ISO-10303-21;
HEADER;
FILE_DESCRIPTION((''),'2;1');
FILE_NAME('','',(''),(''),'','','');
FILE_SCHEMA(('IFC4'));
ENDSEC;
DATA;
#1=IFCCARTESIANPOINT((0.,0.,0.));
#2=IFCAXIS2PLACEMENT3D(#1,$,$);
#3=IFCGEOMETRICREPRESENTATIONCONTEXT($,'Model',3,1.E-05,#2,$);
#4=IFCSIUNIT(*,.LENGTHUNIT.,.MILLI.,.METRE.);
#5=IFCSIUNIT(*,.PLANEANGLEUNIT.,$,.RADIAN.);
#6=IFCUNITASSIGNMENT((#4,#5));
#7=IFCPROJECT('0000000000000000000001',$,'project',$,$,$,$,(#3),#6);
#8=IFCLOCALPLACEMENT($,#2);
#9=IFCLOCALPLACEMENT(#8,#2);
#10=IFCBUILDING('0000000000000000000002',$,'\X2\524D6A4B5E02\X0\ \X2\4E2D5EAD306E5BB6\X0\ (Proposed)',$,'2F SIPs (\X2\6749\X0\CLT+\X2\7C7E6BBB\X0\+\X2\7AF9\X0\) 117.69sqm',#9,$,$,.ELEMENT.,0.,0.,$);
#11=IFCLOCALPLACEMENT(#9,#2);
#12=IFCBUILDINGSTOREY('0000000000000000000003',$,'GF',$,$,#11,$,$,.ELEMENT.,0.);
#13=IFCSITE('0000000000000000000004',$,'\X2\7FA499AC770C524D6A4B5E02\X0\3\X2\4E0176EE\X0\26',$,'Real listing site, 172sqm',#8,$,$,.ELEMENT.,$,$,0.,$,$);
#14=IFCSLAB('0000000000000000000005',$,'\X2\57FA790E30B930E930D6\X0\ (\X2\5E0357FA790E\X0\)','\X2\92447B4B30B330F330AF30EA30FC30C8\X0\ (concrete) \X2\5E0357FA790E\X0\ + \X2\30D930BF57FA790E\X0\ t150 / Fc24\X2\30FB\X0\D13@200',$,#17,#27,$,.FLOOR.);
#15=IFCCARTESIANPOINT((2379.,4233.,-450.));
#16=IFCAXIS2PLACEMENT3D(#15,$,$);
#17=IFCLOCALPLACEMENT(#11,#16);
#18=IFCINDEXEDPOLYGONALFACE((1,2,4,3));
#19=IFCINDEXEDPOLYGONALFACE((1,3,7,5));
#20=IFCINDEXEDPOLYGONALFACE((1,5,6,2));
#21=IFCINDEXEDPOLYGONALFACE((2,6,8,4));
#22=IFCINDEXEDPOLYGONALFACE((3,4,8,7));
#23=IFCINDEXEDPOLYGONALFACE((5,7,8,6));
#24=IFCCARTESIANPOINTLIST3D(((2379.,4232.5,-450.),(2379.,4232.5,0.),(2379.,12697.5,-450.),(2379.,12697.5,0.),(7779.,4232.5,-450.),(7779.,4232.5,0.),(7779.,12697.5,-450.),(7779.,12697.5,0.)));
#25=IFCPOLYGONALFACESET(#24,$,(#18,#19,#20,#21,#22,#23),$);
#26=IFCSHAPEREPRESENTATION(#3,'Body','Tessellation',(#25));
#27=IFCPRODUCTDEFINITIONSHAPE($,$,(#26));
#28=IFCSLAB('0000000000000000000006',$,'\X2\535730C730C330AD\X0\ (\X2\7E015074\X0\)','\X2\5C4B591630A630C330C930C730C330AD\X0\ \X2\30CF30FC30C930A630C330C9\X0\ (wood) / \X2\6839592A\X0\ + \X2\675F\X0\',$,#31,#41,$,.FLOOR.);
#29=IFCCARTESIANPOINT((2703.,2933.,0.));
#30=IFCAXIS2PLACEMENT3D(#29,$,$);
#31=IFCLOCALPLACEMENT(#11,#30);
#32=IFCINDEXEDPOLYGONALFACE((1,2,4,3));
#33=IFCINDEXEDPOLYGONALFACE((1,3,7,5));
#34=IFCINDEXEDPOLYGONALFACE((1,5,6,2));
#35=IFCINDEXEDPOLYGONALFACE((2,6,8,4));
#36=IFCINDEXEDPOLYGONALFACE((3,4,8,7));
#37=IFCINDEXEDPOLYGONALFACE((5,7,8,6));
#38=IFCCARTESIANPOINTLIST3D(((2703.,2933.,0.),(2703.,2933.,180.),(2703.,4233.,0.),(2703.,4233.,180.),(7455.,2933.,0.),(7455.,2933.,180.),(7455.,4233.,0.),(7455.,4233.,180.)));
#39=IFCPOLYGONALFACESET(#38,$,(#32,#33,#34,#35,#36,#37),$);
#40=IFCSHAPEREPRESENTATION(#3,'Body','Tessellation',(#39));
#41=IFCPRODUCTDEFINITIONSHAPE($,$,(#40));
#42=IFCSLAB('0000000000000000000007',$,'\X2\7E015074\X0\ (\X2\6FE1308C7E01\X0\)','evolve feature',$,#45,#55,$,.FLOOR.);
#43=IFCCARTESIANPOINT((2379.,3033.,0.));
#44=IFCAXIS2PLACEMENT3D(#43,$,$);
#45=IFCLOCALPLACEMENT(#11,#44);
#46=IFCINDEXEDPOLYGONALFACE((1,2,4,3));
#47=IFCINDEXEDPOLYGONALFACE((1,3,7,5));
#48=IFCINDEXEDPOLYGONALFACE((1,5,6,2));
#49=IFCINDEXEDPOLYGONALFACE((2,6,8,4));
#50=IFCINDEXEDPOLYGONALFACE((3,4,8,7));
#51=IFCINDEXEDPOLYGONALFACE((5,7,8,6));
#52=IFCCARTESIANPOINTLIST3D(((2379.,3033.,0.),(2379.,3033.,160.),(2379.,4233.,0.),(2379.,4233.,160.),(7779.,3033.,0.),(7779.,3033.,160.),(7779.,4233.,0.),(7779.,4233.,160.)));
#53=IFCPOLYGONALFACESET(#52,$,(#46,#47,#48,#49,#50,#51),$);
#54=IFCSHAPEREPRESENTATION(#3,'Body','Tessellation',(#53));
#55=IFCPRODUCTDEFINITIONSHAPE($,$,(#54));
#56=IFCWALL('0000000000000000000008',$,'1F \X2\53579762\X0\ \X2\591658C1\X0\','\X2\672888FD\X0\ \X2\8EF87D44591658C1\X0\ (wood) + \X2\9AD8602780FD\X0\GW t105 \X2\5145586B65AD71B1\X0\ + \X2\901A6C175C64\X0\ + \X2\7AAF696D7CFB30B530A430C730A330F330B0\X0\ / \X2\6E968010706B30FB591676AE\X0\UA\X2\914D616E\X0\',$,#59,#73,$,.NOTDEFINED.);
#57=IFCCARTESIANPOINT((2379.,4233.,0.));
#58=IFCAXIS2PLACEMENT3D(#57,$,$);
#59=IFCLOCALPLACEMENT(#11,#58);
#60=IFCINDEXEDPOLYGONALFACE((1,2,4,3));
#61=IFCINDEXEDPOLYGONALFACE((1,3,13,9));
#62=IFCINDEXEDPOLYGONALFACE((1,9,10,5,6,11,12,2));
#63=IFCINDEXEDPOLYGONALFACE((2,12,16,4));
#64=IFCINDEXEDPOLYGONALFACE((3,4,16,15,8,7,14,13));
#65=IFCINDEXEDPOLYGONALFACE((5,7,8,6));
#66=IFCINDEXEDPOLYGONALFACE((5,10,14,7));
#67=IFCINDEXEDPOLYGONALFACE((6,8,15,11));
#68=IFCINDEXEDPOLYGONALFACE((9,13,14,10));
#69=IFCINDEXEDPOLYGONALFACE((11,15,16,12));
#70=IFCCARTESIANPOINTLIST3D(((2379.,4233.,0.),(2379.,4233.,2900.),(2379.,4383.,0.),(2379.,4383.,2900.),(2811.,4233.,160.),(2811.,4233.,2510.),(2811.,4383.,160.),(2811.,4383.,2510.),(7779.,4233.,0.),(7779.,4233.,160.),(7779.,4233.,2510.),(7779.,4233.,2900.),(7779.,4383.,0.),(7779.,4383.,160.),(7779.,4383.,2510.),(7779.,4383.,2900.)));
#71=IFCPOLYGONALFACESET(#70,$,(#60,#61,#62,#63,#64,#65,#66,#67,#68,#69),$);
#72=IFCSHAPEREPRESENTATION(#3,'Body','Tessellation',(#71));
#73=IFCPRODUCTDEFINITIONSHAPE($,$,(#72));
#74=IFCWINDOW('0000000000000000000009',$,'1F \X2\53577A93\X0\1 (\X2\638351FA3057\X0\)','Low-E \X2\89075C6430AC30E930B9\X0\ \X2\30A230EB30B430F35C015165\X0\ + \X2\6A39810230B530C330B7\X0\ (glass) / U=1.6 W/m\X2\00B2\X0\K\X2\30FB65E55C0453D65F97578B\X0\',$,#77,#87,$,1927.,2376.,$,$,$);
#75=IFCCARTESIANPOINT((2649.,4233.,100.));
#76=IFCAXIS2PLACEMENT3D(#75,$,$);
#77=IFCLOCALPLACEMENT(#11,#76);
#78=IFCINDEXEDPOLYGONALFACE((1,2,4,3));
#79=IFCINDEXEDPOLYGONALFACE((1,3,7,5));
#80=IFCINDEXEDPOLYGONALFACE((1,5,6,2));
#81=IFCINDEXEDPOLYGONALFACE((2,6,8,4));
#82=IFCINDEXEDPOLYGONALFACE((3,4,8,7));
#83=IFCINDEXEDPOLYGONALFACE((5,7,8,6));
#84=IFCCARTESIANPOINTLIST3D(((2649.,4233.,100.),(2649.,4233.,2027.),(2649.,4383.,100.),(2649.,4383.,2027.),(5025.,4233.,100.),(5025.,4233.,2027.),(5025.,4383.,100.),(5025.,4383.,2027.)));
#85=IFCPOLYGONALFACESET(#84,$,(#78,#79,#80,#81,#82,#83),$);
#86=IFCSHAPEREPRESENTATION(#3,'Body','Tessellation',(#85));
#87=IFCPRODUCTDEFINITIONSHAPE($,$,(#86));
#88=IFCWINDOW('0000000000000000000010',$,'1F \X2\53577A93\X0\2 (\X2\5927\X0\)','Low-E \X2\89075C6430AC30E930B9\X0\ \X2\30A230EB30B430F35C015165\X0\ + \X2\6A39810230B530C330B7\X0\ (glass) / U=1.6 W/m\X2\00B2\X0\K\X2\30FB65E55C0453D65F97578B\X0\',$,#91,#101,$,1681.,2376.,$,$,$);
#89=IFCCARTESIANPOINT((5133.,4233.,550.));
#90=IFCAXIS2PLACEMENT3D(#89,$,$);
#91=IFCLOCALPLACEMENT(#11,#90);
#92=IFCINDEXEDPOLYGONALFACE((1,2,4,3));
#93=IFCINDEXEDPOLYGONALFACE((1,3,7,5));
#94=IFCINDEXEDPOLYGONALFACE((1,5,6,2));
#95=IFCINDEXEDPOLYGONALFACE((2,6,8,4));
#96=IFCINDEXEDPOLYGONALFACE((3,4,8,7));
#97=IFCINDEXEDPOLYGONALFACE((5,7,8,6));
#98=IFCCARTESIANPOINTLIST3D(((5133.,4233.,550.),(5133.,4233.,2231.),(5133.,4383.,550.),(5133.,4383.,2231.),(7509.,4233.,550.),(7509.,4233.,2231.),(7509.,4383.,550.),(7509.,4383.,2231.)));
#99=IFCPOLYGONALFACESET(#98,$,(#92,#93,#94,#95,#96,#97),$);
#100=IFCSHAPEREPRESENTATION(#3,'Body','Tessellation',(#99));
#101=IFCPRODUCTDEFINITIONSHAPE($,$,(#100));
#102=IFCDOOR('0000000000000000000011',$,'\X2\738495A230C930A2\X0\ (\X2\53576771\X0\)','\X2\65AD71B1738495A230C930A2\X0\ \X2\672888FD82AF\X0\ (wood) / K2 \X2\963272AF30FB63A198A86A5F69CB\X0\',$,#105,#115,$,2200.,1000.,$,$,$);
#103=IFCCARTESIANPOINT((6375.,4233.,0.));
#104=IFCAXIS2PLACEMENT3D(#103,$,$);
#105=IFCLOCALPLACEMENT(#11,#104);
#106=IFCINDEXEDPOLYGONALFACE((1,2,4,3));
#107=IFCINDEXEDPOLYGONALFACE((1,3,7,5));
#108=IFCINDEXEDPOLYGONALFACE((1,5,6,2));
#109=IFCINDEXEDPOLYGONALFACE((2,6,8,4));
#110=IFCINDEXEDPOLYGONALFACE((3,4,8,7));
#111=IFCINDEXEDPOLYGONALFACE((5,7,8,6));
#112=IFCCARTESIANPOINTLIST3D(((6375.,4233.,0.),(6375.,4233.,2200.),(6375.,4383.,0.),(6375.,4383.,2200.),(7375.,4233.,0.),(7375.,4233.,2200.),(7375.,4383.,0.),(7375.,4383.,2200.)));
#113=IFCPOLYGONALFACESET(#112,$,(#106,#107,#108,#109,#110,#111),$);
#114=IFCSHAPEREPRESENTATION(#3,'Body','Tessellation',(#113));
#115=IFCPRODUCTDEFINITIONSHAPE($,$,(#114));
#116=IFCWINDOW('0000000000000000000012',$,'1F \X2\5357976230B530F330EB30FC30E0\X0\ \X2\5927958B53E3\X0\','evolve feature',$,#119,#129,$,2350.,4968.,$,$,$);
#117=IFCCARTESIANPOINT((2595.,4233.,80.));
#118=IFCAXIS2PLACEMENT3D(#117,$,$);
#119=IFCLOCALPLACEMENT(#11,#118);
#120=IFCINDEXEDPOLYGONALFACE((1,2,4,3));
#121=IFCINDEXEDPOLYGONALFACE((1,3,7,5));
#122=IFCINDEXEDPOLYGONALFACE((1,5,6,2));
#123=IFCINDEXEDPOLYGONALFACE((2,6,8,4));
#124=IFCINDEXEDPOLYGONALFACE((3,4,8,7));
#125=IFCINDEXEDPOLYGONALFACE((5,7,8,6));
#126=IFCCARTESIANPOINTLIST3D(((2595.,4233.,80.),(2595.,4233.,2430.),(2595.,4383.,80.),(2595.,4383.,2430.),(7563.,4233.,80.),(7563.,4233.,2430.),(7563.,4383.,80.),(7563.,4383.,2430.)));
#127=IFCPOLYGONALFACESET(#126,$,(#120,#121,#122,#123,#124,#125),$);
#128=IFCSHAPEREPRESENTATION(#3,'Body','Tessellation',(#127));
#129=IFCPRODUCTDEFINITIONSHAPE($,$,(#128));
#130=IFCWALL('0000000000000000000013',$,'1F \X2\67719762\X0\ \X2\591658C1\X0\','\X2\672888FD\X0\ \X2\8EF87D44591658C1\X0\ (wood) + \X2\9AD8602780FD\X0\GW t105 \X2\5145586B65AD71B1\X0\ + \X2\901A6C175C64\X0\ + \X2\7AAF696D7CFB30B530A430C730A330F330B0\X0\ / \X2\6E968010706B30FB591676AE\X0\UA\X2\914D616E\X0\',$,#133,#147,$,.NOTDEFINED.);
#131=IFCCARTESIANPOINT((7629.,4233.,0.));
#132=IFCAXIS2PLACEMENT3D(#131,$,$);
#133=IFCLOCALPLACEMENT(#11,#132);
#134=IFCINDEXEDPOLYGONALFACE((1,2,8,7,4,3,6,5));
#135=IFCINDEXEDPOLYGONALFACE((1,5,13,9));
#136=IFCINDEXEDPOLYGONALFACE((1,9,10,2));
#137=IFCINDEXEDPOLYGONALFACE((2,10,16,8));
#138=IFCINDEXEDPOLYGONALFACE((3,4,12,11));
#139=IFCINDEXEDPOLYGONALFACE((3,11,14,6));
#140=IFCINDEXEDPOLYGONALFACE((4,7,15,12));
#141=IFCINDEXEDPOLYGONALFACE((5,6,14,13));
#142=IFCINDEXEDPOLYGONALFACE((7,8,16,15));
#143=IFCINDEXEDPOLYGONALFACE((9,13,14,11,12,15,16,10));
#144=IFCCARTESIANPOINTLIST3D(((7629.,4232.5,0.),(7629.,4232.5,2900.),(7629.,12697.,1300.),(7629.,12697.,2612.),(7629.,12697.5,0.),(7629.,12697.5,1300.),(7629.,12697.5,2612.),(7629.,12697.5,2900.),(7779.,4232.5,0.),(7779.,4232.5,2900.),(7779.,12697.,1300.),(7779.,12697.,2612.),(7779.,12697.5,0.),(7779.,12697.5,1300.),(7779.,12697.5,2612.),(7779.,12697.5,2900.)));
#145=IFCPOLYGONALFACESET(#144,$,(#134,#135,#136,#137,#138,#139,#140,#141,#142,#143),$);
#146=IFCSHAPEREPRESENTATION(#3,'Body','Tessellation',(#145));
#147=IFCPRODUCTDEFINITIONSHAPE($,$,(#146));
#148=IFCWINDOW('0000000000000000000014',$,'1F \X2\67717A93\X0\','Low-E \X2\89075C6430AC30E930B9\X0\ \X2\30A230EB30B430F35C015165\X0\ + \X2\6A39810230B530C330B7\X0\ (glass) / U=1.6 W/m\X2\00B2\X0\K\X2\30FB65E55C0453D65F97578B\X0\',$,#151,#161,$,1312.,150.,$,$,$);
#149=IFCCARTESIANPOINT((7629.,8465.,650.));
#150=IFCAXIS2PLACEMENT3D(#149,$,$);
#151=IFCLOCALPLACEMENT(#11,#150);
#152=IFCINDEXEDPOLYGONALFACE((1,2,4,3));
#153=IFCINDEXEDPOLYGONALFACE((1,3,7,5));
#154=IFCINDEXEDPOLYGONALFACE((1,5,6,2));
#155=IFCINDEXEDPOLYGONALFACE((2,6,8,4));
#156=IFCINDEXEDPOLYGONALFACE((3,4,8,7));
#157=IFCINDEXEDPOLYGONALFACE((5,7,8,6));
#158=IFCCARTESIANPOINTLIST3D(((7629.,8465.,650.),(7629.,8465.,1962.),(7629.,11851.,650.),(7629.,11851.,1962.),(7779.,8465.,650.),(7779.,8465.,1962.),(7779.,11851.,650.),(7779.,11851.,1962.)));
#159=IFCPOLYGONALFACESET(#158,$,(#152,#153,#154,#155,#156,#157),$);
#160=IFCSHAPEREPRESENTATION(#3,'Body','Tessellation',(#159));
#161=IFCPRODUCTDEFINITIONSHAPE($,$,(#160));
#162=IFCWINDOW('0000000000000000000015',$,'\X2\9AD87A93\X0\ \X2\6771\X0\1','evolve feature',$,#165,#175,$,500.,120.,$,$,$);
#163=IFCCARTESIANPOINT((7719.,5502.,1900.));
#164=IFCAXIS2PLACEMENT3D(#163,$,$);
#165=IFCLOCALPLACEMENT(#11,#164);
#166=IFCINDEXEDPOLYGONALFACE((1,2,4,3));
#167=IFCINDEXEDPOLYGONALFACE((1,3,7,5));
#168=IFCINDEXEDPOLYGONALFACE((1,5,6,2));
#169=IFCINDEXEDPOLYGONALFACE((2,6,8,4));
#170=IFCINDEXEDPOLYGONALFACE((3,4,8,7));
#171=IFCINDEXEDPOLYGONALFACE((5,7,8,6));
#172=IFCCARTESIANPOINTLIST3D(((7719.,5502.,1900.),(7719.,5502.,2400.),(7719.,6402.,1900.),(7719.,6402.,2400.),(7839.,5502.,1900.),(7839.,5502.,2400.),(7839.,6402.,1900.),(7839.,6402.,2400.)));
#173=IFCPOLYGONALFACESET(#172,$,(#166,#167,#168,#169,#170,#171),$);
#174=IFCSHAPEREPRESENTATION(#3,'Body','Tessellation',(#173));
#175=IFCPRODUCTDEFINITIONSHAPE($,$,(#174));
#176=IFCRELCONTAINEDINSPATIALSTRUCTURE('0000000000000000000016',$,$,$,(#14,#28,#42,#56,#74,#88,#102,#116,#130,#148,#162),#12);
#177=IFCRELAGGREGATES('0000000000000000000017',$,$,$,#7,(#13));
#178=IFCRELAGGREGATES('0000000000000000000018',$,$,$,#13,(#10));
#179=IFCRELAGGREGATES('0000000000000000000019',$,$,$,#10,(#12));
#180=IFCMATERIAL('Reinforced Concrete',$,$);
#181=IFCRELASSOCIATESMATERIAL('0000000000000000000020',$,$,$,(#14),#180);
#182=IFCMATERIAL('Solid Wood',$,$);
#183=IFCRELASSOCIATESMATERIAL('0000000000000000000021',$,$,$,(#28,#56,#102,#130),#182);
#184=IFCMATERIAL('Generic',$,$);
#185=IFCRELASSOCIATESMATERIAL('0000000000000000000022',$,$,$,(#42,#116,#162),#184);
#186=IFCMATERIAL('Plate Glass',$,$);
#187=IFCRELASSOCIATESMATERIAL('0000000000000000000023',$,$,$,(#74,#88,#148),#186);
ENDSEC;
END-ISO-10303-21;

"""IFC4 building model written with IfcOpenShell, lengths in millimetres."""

from ifc_helpers import new_model, si_unit, frame, frame_2d, origin, place, context, project, spatial, rectangle, extrude, material, element, fill, save


model = new_model("IFC4")

# Units and contexts
model_context = context("Model", 3, precision=1e-05, world=origin())
ifc_project = project(units=[si_unit("LENGTHUNIT", "METRE", prefix="MILLI"), si_unit("PLANEANGLEUNIT", "RADIAN")], contexts=[model_context])

# Site, building, storey
site_placement = place(None, origin())
site = spatial("IfcSite", under=ifc_project, at=site_placement, Name="群馬県前橋市3丁目26", ObjectType="Real listing site, 172sqm", CompositionType="ELEMENT", RefElevation=0.0)
building_placement = place(site_placement, origin())
building = spatial("IfcBuilding", under=site, at=building_placement, Name="前橋市 中庭の家 (Proposed)", ObjectType="2F SIPs (杉CLT+籾殻+竹) 117.69sqm", CompositionType="ELEMENT", ElevationOfRefHeight=0.0, ElevationOfTerrain=0.0)
storey_placement = place(building_placement, origin())
storey = spatial("IfcBuildingStorey", under=building, at=storey_placement, Name="GF", CompositionType="ELEMENT", Elevation=0.0)

# Slabs
ifc_material_1 = material(Name="Reinforced Concrete")
slab_1_placement = place(storey_placement, frame((2379.0, 4233.0, -450.0)))
element("IfcSlab", 1, at=slab_1_placement, inside=storey, material=ifc_material_1, Name="基礎スラブ (布基礎)", Description="鉄筋コンクリート (concrete) 布基礎 + ベタ基礎 t150 / Fc24・D13@200", PredefinedType="FLOOR", context=model_context, shape_type="SweptSolid", body=[
    extrude(rectangle(XDim=5400.0, YDim=8465.0, at=frame_2d((2700.0, 4232.0))), frame((2379.0, 4233.0, -450.0)), (0.0, 0.0, 1.0), 450.0),
])
ifc_material_2 = material(Name="Solid Wood")
slab_2_placement = place(storey_placement, frame((2703.0, 2933.0, 0.0)))
element("IfcSlab", 2, at=slab_2_placement, inside=storey, material=ifc_material_2, Name="南デッキ (縁側)", Description="屋外ウッドデッキ ハードウッド (wood) / 根太 + 束", PredefinedType="FLOOR", context=model_context, shape_type="SweptSolid", body=[
    extrude(rectangle(XDim=4752.0, YDim=1300.0, at=frame_2d((2376.0, 650.0))), frame((2703.0, 2933.0, 0.0)), (0.0, 0.0, 1.0), 180.0),
])
ifc_material_3 = material(Name="Generic")
slab_3_placement = place(storey_placement, frame((2379.0, 3033.0, 0.0)))
element("IfcSlab", 3, at=slab_3_placement, inside=storey, material=ifc_material_3, Name="縁側 (濡れ縁)", Description="evolve feature", PredefinedType="FLOOR", context=model_context, shape_type="SweptSolid", body=[
    extrude(rectangle(XDim=5400.0, YDim=1200.0, at=frame_2d((2700.0, 600.0))), frame((2379.0, 3033.0, 0.0)), (0.0, 0.0, 1.0), 160.0),
])

# Wall, openings, windows, door
wall_1_placement = place(storey_placement, frame((2379.0, 4233.0, 0.0)))
wall_1 = element("IfcWall", 4, at=wall_1_placement, inside=storey, material=ifc_material_2, Name="1F 南面 外壁", Description="木製 軸組外壁 (wood) + 高性能GW t105 充填断熱 + 通気層 + 窯業系サイディング / 準耐火・外皮UA配慮", PredefinedType="NOTDEFINED", context=model_context, shape_type="SweptSolid", body=[
    extrude(rectangle(XDim=5400.0, YDim=150.0, at=frame_2d((2700.0, 75.0))), frame((2379.0, 4233.0, 0.0)), (0.0, 0.0, 1.0), 2900.0),
])
opening_1_placement = place(storey_placement, frame((2649.0, 4233.0, 100.0)))
opening_1 = element("IfcOpeningElement", 5, at=opening_1_placement, cuts=wall_1, PredefinedType="NOTDEFINED", context=model_context, shape_type="SweptSolid", body=[
    extrude(rectangle(XDim=2376.0, YDim=150.0, at=frame_2d((1188.0, 75.0))), frame((2649.0, 4233.0, 100.0)), (0.0, 0.0, 1.0), 1927.0),
])
opening_2_placement = place(storey_placement, frame((5133.0, 4233.0, 550.0)))
opening_2 = element("IfcOpeningElement", 6, at=opening_2_placement, cuts=wall_1, PredefinedType="NOTDEFINED", context=model_context, shape_type="SweptSolid", body=[
    extrude(rectangle(XDim=2376.0, YDim=150.0, at=frame_2d((1188.0, 75.0))), frame((5133.0, 4233.0, 550.0)), (0.0, 0.0, 1.0), 1681.0),
])
opening_3_placement = place(storey_placement, frame((6375.0, 4233.0, 0.0)))
opening_3 = element("IfcOpeningElement", 7, at=opening_3_placement, cuts=wall_1, PredefinedType="NOTDEFINED", context=model_context, shape_type="SweptSolid", body=[
    extrude(rectangle(XDim=1000.0, YDim=150.0, at=frame_2d((500.0, 75.0))), frame((6375.0, 4233.0, 0.0)), (0.0, 0.0, 1.0), 2200.0),
])
opening_4_placement = place(storey_placement, frame((2595.0, 4233.0, 80.0)))
opening_4 = element("IfcOpeningElement", 8, at=opening_4_placement, cuts=wall_1, PredefinedType="NOTDEFINED", context=model_context, shape_type="SweptSolid", body=[
    extrude(rectangle(XDim=4968.0, YDim=150.0, at=frame_2d((2484.0, 75.0))), frame((2595.0, 4233.0, 80.0)), (0.0, 0.0, 1.0), 2350.0),
])
ifc_material_4 = material(Name="Plate Glass")
window_1_placement = place(storey_placement, frame((2649.0, 4233.0, 100.0)))
window_1 = element("IfcWindow", 9, at=window_1_placement, inside=storey, material=ifc_material_4, Name="1F 南窓1 (掃出し)", Description="Low-E 複層ガラス アルゴン封入 + 樹脂サッシ (glass) / U=1.6 W/m²K・日射取得型", OverallHeight=1927.0, OverallWidth=2376.0, context=model_context, shape_type="SweptSolid", body=[
    extrude(rectangle(XDim=2376.0, YDim=150.0, at=frame_2d((1188.0, 75.0))), frame((2649.0, 4233.0, 100.0)), (0.0, 0.0, 1.0), 1927.0),
])
fill(opening_1, window_1)
window_2_placement = place(storey_placement, frame((5133.0, 4233.0, 550.0)))
window_2 = element("IfcWindow", 10, at=window_2_placement, inside=storey, material=ifc_material_4, Name="1F 南窓2 (大)", Description="Low-E 複層ガラス アルゴン封入 + 樹脂サッシ (glass) / U=1.6 W/m²K・日射取得型", OverallHeight=1681.0, OverallWidth=2376.0, context=model_context, shape_type="SweptSolid", body=[
    extrude(rectangle(XDim=2376.0, YDim=150.0, at=frame_2d((1188.0, 75.0))), frame((5133.0, 4233.0, 550.0)), (0.0, 0.0, 1.0), 1681.0),
])
fill(opening_2, window_2)
door_placement = place(storey_placement, frame((6375.0, 4233.0, 0.0)))
door = element("IfcDoor", 11, at=door_placement, inside=storey, material=ifc_material_2, Name="玄関ドア (南東)", Description="断熱玄関ドア 木製芯 (wood) / K2 防犯・採風機構", OverallHeight=2200.0, OverallWidth=1000.0, context=model_context, shape_type="SweptSolid", body=[
    extrude(rectangle(XDim=1000.0, YDim=150.0, at=frame_2d((500.0, 75.0))), frame((6375.0, 4233.0, 0.0)), (0.0, 0.0, 1.0), 2200.0),
])
fill(opening_3, door)
window_3_placement = place(storey_placement, frame((2595.0, 4233.0, 80.0)))
window_3 = element("IfcWindow", 12, at=window_3_placement, inside=storey, material=ifc_material_3, Name="1F 南面サンルーム 大開口", Description="evolve feature", OverallHeight=2350.0, OverallWidth=4968.0, context=model_context, shape_type="SweptSolid", body=[
    extrude(rectangle(XDim=4968.0, YDim=150.0, at=frame_2d((2484.0, 75.0))), frame((2595.0, 4233.0, 80.0)), (0.0, 0.0, 1.0), 2350.0),
])
fill(opening_4, window_3)

# Wall, openings, windows
wall_2_placement = place(storey_placement, frame((7629.0, 4233.0, 0.0)))
wall_2 = element("IfcWall", 13, at=wall_2_placement, inside=storey, material=ifc_material_2, Name="1F 東面 外壁", Description="木製 軸組外壁 (wood) + 高性能GW t105 充填断熱 + 通気層 + 窯業系サイディング / 準耐火・外皮UA配慮", PredefinedType="NOTDEFINED", context=model_context, shape_type="SweptSolid", body=[
    extrude(rectangle(XDim=150.0, YDim=8465.0, at=frame_2d((75.0, 4232.0))), frame((7629.0, 4233.0, 0.0)), (0.0, 0.0, 1.0), 2900.0),
])
opening_5_placement = place(storey_placement, frame((7629.0, 8465.0, 650.0)))
opening_5 = element("IfcOpeningElement", 14, at=opening_5_placement, cuts=wall_2, PredefinedType="NOTDEFINED", context=model_context, shape_type="SweptSolid", body=[
    extrude(rectangle(XDim=150.0, YDim=3386.0, at=frame_2d((75.0, 1693.0))), frame((7629.0, 8465.0, 650.0)), (0.0, 0.0, 1.0), 1312.0),
])
opening_6_placement = place(storey_placement, frame((7719.0, 5502.0, 1900.0)))
opening_6 = element("IfcOpeningElement", 15, at=opening_6_placement, cuts=wall_2, PredefinedType="NOTDEFINED", context=model_context, shape_type="SweptSolid", body=[
    extrude(rectangle(XDim=120.0, YDim=900.0, at=frame_2d((60.0, 450.0))), frame((7719.0, 5502.0, 1900.0)), (0.0, 0.0, 1.0), 500.0),
])
window_4_placement = place(storey_placement, frame((7629.0, 8465.0, 650.0)))
window_4 = element("IfcWindow", 16, at=window_4_placement, inside=storey, material=ifc_material_4, Name="1F 東窓", Description="Low-E 複層ガラス アルゴン封入 + 樹脂サッシ (glass) / U=1.6 W/m²K・日射取得型", OverallHeight=1312.0, OverallWidth=150.0, context=model_context, shape_type="SweptSolid", body=[
    extrude(rectangle(XDim=150.0, YDim=3386.0, at=frame_2d((75.0, 1693.0))), frame((7629.0, 8465.0, 650.0)), (0.0, 0.0, 1.0), 1312.0),
])
fill(opening_5, window_4)
window_5_placement = place(storey_placement, frame((7719.0, 5502.0, 1900.0)))
window_5 = element("IfcWindow", 17, at=window_5_placement, inside=storey, material=ifc_material_3, Name="高窓 東1", Description="evolve feature", OverallHeight=500.0, OverallWidth=120.0, context=model_context, shape_type="SweptSolid", body=[
    extrude(rectangle(XDim=120.0, YDim=900.0, at=frame_2d((60.0, 450.0))), frame((7719.0, 5502.0, 1900.0)), (0.0, 0.0, 1.0), 500.0),
])
fill(opening_6, window_5)

save(model, "model.ifc")
